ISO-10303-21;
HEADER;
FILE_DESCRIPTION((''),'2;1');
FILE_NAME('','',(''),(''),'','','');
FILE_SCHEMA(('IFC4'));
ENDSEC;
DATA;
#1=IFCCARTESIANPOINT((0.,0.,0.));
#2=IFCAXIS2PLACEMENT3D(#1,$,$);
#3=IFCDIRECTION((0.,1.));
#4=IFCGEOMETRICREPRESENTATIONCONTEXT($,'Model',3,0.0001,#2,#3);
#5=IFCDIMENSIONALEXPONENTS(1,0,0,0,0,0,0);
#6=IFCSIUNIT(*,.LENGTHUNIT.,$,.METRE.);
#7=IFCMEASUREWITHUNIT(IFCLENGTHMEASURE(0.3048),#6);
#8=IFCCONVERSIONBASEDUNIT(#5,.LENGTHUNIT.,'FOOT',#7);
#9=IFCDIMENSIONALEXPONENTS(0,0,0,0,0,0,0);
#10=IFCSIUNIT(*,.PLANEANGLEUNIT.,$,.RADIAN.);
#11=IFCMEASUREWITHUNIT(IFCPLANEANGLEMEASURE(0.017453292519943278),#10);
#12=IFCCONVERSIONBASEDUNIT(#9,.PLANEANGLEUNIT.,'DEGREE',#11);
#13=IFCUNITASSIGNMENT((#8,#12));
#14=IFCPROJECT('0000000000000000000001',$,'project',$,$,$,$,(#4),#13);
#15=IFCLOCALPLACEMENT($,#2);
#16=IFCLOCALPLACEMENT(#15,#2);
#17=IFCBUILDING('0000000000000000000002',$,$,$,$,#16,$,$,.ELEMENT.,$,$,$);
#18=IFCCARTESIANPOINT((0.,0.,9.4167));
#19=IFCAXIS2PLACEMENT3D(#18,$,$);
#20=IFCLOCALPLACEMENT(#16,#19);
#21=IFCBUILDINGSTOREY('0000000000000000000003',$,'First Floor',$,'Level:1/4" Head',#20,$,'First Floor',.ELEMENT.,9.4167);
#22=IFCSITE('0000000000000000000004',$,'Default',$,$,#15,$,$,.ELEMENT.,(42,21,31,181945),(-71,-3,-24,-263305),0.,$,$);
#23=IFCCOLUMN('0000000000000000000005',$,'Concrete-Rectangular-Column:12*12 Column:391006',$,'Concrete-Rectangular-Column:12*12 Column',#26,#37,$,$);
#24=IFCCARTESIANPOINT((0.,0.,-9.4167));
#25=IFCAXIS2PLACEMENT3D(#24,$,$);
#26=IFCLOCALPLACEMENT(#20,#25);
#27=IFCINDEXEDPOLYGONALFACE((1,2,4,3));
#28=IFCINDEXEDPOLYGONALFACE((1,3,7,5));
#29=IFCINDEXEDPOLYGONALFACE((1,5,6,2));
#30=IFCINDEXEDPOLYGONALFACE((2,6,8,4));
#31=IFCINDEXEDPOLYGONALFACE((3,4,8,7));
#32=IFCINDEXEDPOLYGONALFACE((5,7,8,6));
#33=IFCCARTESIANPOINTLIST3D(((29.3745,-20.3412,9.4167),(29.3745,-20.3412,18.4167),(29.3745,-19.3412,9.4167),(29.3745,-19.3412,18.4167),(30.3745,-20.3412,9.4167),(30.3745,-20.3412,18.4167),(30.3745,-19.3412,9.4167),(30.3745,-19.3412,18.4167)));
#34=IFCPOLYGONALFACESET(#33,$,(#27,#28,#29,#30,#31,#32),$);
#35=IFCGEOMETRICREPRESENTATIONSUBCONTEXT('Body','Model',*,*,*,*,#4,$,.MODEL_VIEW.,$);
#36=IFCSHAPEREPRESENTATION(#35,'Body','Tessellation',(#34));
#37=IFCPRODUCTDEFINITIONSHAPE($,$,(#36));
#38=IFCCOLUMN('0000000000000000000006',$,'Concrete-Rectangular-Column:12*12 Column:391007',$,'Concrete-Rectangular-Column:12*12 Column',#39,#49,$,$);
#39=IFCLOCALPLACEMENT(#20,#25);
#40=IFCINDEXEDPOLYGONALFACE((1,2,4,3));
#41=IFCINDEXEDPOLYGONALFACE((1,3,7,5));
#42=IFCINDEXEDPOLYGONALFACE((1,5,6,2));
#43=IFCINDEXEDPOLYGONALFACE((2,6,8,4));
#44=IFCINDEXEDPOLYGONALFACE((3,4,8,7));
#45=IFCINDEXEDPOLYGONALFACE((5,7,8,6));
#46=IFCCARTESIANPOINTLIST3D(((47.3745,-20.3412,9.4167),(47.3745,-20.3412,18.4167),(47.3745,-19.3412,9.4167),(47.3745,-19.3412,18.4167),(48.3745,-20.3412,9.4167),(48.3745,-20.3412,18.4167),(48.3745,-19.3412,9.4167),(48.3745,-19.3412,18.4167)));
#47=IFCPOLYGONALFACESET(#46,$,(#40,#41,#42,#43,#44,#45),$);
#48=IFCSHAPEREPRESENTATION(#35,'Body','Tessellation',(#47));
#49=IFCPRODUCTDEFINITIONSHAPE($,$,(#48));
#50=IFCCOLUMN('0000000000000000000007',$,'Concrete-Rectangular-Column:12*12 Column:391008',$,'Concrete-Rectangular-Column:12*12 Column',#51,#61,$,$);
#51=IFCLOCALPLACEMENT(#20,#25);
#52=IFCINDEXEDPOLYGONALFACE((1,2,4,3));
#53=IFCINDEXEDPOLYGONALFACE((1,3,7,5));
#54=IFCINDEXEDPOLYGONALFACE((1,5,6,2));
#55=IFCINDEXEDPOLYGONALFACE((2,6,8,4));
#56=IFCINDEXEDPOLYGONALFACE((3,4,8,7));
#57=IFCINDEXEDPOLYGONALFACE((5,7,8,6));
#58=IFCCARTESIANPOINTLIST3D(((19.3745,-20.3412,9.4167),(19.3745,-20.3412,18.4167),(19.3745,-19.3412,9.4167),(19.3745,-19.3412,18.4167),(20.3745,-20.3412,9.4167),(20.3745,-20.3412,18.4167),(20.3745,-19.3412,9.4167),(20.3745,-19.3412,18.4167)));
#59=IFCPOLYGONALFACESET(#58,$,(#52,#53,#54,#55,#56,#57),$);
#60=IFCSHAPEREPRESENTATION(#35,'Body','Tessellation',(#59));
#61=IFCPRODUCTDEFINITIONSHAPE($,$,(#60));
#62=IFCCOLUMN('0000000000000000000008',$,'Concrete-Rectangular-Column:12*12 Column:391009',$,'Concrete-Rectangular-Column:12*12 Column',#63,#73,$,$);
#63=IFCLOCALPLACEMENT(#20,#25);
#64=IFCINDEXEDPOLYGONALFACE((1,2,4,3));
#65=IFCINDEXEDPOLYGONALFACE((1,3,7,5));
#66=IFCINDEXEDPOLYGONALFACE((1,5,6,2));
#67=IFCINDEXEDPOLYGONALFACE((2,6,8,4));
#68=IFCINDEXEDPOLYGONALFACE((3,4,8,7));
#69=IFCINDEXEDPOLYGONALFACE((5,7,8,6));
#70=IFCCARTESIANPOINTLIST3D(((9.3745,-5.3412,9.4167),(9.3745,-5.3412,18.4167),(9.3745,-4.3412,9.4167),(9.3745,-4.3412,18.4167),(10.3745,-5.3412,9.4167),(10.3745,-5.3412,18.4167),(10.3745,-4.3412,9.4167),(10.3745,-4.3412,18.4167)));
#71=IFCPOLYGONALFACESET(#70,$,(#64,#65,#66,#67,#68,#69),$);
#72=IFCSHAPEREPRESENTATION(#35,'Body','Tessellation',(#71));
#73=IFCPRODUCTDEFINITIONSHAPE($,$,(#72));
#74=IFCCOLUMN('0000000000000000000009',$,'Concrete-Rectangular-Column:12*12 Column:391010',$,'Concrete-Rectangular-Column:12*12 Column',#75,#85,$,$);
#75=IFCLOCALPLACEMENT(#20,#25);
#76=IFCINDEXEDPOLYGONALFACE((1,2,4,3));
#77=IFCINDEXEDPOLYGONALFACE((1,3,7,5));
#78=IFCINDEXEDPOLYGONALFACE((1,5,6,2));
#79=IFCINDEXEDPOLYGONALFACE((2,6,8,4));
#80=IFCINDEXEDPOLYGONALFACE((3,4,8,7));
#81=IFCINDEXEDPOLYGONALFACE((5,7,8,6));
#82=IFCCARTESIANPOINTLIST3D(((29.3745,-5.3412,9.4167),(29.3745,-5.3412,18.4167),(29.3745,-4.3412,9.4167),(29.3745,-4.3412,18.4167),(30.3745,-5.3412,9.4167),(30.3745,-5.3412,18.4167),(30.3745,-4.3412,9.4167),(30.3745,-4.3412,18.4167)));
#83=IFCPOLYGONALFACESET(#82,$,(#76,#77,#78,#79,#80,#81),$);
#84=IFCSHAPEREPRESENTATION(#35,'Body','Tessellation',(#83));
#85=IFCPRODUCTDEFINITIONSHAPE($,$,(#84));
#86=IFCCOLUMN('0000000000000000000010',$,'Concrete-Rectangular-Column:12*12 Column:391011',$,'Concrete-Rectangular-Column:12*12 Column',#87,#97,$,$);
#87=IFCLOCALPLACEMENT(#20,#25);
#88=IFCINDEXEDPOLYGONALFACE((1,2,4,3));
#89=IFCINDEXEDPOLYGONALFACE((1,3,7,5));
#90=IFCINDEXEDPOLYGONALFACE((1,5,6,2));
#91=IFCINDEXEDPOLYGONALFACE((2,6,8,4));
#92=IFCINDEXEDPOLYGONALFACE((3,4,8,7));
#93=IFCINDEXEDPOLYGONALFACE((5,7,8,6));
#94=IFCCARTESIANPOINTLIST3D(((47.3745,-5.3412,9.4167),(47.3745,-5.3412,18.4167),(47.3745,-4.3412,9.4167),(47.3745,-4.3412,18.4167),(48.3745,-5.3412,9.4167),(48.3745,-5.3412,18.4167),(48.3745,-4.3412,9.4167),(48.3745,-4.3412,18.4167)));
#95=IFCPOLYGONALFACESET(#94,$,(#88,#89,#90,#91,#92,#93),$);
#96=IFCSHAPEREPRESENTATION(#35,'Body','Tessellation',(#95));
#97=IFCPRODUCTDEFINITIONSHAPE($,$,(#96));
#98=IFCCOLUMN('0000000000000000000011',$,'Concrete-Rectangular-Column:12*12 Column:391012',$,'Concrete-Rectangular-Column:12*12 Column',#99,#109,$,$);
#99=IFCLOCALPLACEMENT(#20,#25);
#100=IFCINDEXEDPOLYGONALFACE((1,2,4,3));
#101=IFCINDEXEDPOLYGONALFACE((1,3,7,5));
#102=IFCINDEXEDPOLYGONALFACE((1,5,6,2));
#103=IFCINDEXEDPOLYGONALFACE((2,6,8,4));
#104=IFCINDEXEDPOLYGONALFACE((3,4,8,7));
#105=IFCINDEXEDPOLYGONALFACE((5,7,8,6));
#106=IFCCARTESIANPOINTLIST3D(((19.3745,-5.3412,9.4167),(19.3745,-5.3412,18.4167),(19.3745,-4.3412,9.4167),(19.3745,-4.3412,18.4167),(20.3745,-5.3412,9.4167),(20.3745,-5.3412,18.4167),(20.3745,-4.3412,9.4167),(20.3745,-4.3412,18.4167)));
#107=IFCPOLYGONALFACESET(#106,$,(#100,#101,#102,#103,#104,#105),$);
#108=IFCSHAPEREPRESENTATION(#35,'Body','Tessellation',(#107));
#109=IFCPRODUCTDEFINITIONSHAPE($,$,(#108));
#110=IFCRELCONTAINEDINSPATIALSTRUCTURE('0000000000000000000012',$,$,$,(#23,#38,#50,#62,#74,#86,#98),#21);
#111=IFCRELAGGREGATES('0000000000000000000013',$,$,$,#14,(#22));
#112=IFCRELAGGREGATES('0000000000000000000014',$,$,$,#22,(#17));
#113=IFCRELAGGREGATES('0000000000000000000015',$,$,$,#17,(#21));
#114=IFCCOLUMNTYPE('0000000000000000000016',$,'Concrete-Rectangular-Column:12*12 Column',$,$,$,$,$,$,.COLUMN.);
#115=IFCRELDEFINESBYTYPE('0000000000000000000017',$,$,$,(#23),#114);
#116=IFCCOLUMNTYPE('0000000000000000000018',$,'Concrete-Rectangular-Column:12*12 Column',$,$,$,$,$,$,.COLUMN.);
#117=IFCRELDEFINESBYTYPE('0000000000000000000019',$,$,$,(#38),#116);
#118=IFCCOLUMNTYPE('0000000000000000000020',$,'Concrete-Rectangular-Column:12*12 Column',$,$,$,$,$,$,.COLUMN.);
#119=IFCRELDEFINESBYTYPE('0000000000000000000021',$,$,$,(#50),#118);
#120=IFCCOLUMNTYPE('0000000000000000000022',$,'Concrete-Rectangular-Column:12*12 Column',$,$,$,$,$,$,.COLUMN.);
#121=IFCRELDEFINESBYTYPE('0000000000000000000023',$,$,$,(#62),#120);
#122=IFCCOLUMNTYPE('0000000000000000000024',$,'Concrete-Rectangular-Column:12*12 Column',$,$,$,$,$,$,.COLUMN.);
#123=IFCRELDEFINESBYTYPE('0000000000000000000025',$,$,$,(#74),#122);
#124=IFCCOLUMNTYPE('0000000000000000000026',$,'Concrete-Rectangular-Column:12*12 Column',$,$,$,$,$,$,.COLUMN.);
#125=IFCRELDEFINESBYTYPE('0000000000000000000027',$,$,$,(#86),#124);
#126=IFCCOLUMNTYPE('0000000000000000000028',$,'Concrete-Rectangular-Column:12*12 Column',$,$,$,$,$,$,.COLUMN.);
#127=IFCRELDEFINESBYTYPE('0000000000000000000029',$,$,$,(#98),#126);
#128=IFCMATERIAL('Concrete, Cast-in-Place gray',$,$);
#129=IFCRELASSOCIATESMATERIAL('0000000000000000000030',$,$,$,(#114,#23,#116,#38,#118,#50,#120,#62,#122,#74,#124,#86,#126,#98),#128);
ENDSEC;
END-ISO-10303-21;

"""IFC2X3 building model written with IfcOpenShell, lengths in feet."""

from ifc_helpers import new_model, entity, si_unit, converted_unit, direction, frame, frame_2d, origin, origin_2d_with_axis, place, context, subcontext, project, spatial, rectangle, extrude, source, transform, mapped, material, type_object, type_shapes, element, save


model = new_model("IFC2X3")

# Units and contexts
model_context = context("Model", 3, precision=0.0001, world=origin(), true_north=direction((0.0, 1.0)))
body_context = subcontext(model_context, "Body", "Model", "MODEL_VIEW")
ifc_project = project(units=[converted_unit("LENGTHUNIT", "FOOT", entity("IfcLengthMeasure", 0.3048), si_unit("LENGTHUNIT", "METRE"), dimensions=[1, 0, 0, 0, 0, 0, 0]), converted_unit("PLANEANGLEUNIT", "DEGREE", entity("IfcPlaneAngleMeasure", 0.017453292519943278), si_unit("PLANEANGLEUNIT", "RADIAN"), dimensions=[0, 0, 0, 0, 0, 0, 0])], contexts=[model_context])

# Site, building, storey
site_placement = place(None, origin())
site = spatial("IfcSite", under=ifc_project, at=site_placement, Name="Default", CompositionType="ELEMENT", RefLatitude=(42, 21, 31, 181945), RefLongitude=(-71, -3, -24, -263305), RefElevation=0.0)
building_placement = place(site_placement, origin())
building = spatial("IfcBuilding", under=site, at=building_placement, CompositionType="ELEMENT")
storey_placement = place(building_placement, frame((0.0, 0.0, 9.4167)))
storey = spatial("IfcBuildingStorey", under=building, at=storey_placement, Name="First Floor", ObjectType="Level:1/4\" Head", LongName="First Floor", CompositionType="ELEMENT", Elevation=9.4167)

# Columns
ifc_material_1 = material(Name="Concrete, Cast-in-Place gray")
column_type_1 = type_object("IfcColumnType", Name="Concrete-Rectangular-Column:12*12 Column", PredefinedType="COLUMN", material=ifc_material_1)
shared_shape_1 = source(origin(), body_context, "Body", "SweptSolid", [
    extrude(rectangle(XDim=1.0, YDim=1.0, at=frame_2d((0.0, 0.0), x_axis=(1.0, 0.0))), frame((29.8745, -19.8412, 9.4167), z_axis=(0.0, 0.0, 1.0), x_axis=(-1.0, 0.0, 0.0)), (0.0, 0.0, 1.0), 9.0),
])
type_shapes(column_type_1, [shared_shape_1])
column_1_placement = place(storey_placement, frame((0.0, 0.0, -9.4167)))
element("IfcColumn", 1, at=column_1_placement, inside=storey, type_object=column_type_1, material=ifc_material_1, Name="Concrete-Rectangular-Column:12*12 Column:391006", ObjectType="Concrete-Rectangular-Column:12*12 Column", context=body_context, shape_type="MappedRepresentation", body=[
    mapped(shared_shape_1, transform((0.0, 0.0, 0.0), scale=1.0)),
])
column_type_2 = type_object("IfcColumnType", Name="Concrete-Rectangular-Column:12*12 Column", PredefinedType="COLUMN", material=ifc_material_1)
shared_shape_2 = source(origin(), body_context, "Body", "SweptSolid", [
    extrude(rectangle(XDim=1.0, YDim=1.0, at=frame_2d((0.0, 0.0), x_axis=(1.0, 0.0))), frame((47.8745, -19.8412, 9.4167), z_axis=(0.0, 0.0, 1.0), x_axis=(-1.0, 0.0, 0.0)), (0.0, 0.0, 1.0), 9.0),
])
type_shapes(column_type_2, [shared_shape_2])
column_2_placement = place(storey_placement, frame((0.0, 0.0, -9.4167)))
element("IfcColumn", 2, at=column_2_placement, inside=storey, type_object=column_type_2, material=ifc_material_1, Name="Concrete-Rectangular-Column:12*12 Column:391007", ObjectType="Concrete-Rectangular-Column:12*12 Column", context=body_context, shape_type="MappedRepresentation", body=[
    mapped(shared_shape_2, transform((0.0, 0.0, 0.0), scale=1.0)),
])
column_type_3 = type_object("IfcColumnType", Name="Concrete-Rectangular-Column:12*12 Column", PredefinedType="COLUMN", material=ifc_material_1)
shared_shape_3 = source(origin(), body_context, "Body", "SweptSolid", [
    extrude(rectangle(XDim=1.0, YDim=1.0, at=frame_2d((0.0, 0.0), x_axis=(1.0, 0.0))), frame((19.8745, -19.8412, 9.4167), z_axis=(0.0, 0.0, 1.0), x_axis=(-1.0, 0.0, 0.0)), (0.0, 0.0, 1.0), 9.0),
])
type_shapes(column_type_3, [shared_shape_3])
column_3_placement = place(storey_placement, frame((0.0, 0.0, -9.4167)))
element("IfcColumn", 3, at=column_3_placement, inside=storey, type_object=column_type_3, material=ifc_material_1, Name="Concrete-Rectangular-Column:12*12 Column:391008", ObjectType="Concrete-Rectangular-Column:12*12 Column", context=body_context, shape_type="MappedRepresentation", body=[
    mapped(shared_shape_3, transform((0.0, 0.0, 0.0), scale=1.0)),
])
column_type_4 = type_object("IfcColumnType", Name="Concrete-Rectangular-Column:12*12 Column", PredefinedType="COLUMN", material=ifc_material_1)
shared_shape_4 = source(origin(), body_context, "Body", "SweptSolid", [
    extrude(rectangle(XDim=1.0, YDim=1.0, at=origin_2d_with_axis()), frame((9.8745, -4.8412, 9.4167), z_axis=(0.0, 0.0, 1.0), x_axis=(-1.0, 0.0, 0.0)), (0.0, 0.0, 1.0), 9.0),
])
type_shapes(column_type_4, [shared_shape_4])
column_4_placement = place(storey_placement, frame((0.0, 0.0, -9.4167)))
element("IfcColumn", 4, at=column_4_placement, inside=storey, type_object=column_type_4, material=ifc_material_1, Name="Concrete-Rectangular-Column:12*12 Column:391009", ObjectType="Concrete-Rectangular-Column:12*12 Column", context=body_context, shape_type="MappedRepresentation", body=[
    mapped(shared_shape_4, transform((0.0, 0.0, 0.0), scale=1.0)),
])
column_type_5 = type_object("IfcColumnType", Name="Concrete-Rectangular-Column:12*12 Column", PredefinedType="COLUMN", material=ifc_material_1)
shared_shape_5 = source(origin(), body_context, "Body", "SweptSolid", [
    extrude(rectangle(XDim=1.0, YDim=1.0, at=frame_2d((0.0, 0.0), x_axis=(1.0, 0.0))), frame((29.8745, -4.8412, 9.4167), z_axis=(0.0, 0.0, 1.0), x_axis=(-1.0, 0.0, 0.0)), (0.0, 0.0, 1.0), 9.0),
])
type_shapes(column_type_5, [shared_shape_5])
column_5_placement = place(storey_placement, frame((0.0, 0.0, -9.4167)))
element("IfcColumn", 5, at=column_5_placement, inside=storey, type_object=column_type_5, material=ifc_material_1, Name="Concrete-Rectangular-Column:12*12 Column:391010", ObjectType="Concrete-Rectangular-Column:12*12 Column", context=body_context, shape_type="MappedRepresentation", body=[
    mapped(shared_shape_5, transform((0.0, 0.0, 0.0), scale=1.0)),
])
column_type_6 = type_object("IfcColumnType", Name="Concrete-Rectangular-Column:12*12 Column", PredefinedType="COLUMN", material=ifc_material_1)
shared_shape_6 = source(origin(), body_context, "Body", "SweptSolid", [
    extrude(rectangle(XDim=1.0, YDim=1.0, at=frame_2d((0.0, 0.0), x_axis=(1.0, 0.0))), frame((47.8745, -4.8412, 9.4167), z_axis=(0.0, 0.0, 1.0), x_axis=(-1.0, 0.0, 0.0)), (0.0, 0.0, 1.0), 9.0),
])
type_shapes(column_type_6, [shared_shape_6])
column_6_placement = place(storey_placement, frame((0.0, 0.0, -9.4167)))
element("IfcColumn", 6, at=column_6_placement, inside=storey, type_object=column_type_6, material=ifc_material_1, Name="Concrete-Rectangular-Column:12*12 Column:391011", ObjectType="Concrete-Rectangular-Column:12*12 Column", context=body_context, shape_type="MappedRepresentation", body=[
    mapped(shared_shape_6, transform((0.0, 0.0, 0.0), scale=1.0)),
])
column_type_7 = type_object("IfcColumnType", Name="Concrete-Rectangular-Column:12*12 Column", PredefinedType="COLUMN", material=ifc_material_1)
shared_shape_7 = source(origin(), body_context, "Body", "SweptSolid", [
    extrude(rectangle(XDim=1.0, YDim=1.0, at=frame_2d((0.0, 0.0), x_axis=(1.0, 0.0))), frame((19.8745, -4.8412, 9.4167), z_axis=(0.0, 0.0, 1.0), x_axis=(-1.0, 0.0, 0.0)), (0.0, 0.0, 1.0), 9.0),
])
type_shapes(column_type_7, [shared_shape_7])
column_7_placement = place(storey_placement, frame((0.0, 0.0, -9.4167)))
element("IfcColumn", 7, at=column_7_placement, inside=storey, type_object=column_type_7, material=ifc_material_1, Name="Concrete-Rectangular-Column:12*12 Column:391012", ObjectType="Concrete-Rectangular-Column:12*12 Column", context=body_context, shape_type="MappedRepresentation", body=[
    mapped(shared_shape_7, transform((0.0, 0.0, 0.0), scale=1.0)),
])

save(model, "model.ifc")
